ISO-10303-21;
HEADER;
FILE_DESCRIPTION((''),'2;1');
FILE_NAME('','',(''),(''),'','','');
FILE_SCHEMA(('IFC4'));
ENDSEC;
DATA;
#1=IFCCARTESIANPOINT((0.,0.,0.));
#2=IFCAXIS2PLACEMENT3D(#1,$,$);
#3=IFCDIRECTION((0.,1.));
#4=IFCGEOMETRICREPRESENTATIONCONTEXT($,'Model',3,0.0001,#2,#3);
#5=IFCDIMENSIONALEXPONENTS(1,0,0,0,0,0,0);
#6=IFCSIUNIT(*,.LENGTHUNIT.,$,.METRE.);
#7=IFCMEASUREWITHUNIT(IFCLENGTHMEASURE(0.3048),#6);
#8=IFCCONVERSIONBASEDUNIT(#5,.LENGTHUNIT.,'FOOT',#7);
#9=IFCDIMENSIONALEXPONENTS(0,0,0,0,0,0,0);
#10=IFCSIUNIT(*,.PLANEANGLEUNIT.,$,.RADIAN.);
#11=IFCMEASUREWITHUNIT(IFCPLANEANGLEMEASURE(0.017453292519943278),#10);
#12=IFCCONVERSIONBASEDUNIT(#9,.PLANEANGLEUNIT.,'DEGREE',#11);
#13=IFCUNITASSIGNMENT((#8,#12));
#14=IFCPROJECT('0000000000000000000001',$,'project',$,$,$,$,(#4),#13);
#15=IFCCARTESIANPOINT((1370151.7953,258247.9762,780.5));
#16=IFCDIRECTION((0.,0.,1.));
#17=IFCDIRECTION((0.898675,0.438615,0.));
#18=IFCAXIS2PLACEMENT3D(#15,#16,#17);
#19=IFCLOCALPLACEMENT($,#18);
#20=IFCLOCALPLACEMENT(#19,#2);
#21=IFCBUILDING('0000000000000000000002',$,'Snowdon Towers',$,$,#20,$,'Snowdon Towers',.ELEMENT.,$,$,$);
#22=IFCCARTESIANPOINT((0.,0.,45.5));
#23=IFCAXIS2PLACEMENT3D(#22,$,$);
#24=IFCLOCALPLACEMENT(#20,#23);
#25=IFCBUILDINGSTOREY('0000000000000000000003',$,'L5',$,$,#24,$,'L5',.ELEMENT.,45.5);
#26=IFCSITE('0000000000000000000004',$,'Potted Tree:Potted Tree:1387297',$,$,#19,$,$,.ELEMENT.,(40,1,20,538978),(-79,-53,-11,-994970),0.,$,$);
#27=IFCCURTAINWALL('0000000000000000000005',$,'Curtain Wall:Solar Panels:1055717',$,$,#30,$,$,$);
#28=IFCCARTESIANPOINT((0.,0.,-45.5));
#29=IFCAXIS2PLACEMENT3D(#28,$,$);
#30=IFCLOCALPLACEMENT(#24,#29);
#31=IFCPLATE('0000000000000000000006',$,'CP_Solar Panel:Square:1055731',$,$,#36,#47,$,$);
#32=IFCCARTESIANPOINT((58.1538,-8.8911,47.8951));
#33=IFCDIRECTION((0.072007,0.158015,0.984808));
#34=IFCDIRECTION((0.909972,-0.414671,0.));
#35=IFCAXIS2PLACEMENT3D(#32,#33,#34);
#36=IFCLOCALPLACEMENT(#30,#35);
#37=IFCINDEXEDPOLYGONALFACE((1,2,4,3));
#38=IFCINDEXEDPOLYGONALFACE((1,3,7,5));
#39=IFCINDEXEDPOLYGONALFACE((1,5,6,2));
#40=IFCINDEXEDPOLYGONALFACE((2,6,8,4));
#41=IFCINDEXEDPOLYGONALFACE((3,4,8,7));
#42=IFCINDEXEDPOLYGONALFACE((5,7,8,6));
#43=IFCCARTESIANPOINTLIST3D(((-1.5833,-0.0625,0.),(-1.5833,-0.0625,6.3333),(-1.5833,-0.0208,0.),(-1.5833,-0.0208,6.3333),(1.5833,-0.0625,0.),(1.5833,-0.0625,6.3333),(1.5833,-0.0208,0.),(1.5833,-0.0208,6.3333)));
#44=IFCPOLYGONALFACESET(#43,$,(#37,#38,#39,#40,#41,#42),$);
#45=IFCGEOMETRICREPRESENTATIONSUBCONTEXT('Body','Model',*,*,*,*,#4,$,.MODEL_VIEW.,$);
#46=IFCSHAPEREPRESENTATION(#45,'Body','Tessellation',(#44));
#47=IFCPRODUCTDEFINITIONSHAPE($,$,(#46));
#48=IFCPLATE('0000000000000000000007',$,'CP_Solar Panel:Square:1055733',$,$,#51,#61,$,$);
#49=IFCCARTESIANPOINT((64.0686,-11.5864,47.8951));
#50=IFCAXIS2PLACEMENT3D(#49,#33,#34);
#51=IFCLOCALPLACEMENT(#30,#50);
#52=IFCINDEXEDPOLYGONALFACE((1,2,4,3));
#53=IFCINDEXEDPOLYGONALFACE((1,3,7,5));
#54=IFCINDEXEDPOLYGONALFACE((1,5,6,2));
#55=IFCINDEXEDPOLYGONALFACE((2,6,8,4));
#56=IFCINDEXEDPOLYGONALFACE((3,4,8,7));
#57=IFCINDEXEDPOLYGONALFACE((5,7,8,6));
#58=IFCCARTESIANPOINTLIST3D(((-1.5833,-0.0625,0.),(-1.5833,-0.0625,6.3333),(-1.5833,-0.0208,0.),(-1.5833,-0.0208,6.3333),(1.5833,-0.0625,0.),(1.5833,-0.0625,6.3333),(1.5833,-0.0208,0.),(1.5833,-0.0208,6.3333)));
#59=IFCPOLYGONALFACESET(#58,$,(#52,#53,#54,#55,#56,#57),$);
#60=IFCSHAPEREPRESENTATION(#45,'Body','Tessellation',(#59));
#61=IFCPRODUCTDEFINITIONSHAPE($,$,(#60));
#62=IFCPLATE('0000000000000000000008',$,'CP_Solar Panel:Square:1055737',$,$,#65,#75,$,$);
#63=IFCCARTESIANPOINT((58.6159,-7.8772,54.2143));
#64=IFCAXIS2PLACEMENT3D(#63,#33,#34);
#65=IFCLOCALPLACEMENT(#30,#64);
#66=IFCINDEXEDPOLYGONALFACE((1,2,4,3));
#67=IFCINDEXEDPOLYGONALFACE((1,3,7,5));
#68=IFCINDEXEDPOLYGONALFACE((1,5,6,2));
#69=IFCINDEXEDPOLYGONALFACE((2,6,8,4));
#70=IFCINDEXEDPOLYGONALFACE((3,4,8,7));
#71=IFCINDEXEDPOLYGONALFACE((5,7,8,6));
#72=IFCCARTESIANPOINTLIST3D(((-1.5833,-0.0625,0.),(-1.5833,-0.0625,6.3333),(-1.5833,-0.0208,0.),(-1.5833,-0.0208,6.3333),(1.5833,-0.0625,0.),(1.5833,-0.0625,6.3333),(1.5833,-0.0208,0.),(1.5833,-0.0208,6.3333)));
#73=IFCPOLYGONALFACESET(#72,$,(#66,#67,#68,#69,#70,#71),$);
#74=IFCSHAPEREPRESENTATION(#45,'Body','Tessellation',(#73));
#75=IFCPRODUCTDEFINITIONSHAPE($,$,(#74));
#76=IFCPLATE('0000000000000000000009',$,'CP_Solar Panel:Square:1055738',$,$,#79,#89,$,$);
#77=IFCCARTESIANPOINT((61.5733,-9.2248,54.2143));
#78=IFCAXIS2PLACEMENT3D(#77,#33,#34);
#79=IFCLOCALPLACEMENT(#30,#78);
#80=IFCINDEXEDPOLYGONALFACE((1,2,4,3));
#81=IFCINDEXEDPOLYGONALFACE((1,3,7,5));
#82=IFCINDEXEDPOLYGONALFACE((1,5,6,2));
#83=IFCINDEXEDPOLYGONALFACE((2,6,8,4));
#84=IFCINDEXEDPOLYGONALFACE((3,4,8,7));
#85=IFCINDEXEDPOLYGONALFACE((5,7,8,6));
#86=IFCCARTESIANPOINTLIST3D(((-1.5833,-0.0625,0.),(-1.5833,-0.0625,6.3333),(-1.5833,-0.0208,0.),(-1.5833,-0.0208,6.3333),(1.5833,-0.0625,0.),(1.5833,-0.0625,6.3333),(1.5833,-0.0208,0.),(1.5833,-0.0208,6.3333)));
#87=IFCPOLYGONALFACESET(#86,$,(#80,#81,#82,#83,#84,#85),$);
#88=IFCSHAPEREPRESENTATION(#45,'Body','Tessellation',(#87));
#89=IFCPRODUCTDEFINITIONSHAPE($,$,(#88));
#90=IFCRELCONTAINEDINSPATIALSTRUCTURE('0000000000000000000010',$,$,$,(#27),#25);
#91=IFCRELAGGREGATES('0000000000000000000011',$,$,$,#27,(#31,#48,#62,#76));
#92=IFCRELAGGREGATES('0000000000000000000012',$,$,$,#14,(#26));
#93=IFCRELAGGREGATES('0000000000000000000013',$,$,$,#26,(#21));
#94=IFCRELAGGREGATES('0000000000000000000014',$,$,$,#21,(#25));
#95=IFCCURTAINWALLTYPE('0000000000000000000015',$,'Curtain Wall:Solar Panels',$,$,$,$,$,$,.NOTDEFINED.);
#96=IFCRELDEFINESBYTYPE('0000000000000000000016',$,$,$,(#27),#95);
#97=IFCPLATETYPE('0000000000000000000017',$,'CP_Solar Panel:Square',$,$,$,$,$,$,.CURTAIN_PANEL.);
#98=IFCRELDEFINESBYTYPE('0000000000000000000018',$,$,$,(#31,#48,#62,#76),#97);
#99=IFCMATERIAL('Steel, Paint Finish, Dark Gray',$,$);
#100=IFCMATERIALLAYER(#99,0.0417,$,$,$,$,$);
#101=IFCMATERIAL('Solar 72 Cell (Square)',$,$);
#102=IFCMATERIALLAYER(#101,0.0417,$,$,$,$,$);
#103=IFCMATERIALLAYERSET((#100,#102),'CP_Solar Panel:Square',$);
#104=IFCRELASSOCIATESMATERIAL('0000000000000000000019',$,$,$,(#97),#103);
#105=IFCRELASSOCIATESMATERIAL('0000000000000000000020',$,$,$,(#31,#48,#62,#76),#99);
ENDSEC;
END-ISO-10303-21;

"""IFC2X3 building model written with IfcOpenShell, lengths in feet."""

from ifc_helpers import new_model, entity, si_unit, converted_unit, direction, frame, origin, origin_2d_with_axis, place, context, subcontext, project, spatial, rectangle, extrude, source, transform, mapped, material, layer, layer_set, type_object, type_shapes, element, aggregate, save


model = new_model("IFC2X3")

# Units and contexts
model_context = context("Model", 3, precision=0.0001, world=origin(), true_north=direction((0.0, 1.0)))
body_context = subcontext(model_context, "Body", "Model", "MODEL_VIEW")
ifc_project = project(units=[converted_unit("LENGTHUNIT", "FOOT", entity("IfcLengthMeasure", 0.3048), si_unit("LENGTHUNIT", "METRE"), dimensions=[1, 0, 0, 0, 0, 0, 0]), converted_unit("PLANEANGLEUNIT", "DEGREE", entity("IfcPlaneAngleMeasure", 0.017453292519943278), si_unit("PLANEANGLEUNIT", "RADIAN"), dimensions=[0, 0, 0, 0, 0, 0, 0])], contexts=[model_context])

# Site, building, storey
site_placement = place(None, frame((1370151.7953, 258247.9762, 780.5), z_axis=(0.0, 0.0, 1.0), x_axis=(0.898675, 0.438615, 0.0)))
site = spatial("IfcSite", under=ifc_project, at=site_placement, Name="Potted Tree:Potted Tree:1387297", CompositionType="ELEMENT", RefLatitude=(40, 1, 20, 538978), RefLongitude=(-79, -53, -11, -994970), RefElevation=0.0)
building_placement = place(site_placement, origin())
building = spatial("IfcBuilding", under=site, at=building_placement, Name="Snowdon Towers", LongName="Snowdon Towers", CompositionType="ELEMENT")
storey_placement = place(building_placement, frame((0.0, 0.0, 45.5)))
storey = spatial("IfcBuildingStorey", under=building, at=storey_placement, Name="L5", LongName="L5", CompositionType="ELEMENT", Elevation=45.5)

# Curtain wall, plates
curtain_wall_type = type_object("IfcCurtainWallType", Name="Curtain Wall:Solar Panels", PredefinedType="NOTDEFINED")
curtain_wall_placement = place(storey_placement, frame((0.0, 0.0, -45.5)))
curtain_wall = element("IfcCurtainWall", 1, at=curtain_wall_placement, inside=storey, type_object=curtain_wall_type, Name="Curtain Wall:Solar Panels:1055717")
ifc_material_1 = material(Name="Steel, Paint Finish, Dark Gray")
ifc_layer_1 = layer(ifc_material_1, 0.0417)
ifc_material_2 = material(Name="Solar 72 Cell (Square)")
ifc_layer_2 = layer(ifc_material_2, 0.0417)
ifc_layer_set_1 = layer_set([ifc_layer_1, ifc_layer_2], Name="CP_Solar Panel:Square")
plate_type_1 = type_object("IfcPlateType", Name="CP_Solar Panel:Square", PredefinedType="CURTAIN_PANEL", material=ifc_layer_set_1)
shared_shape_1 = source(origin(), body_context, "Body", "SweptSolid", [
    extrude(rectangle(XDim=3.1667, YDim=0.0417, at=origin_2d_with_axis()), frame((0.0, -0.0417, 0.0)), (0.0, 0.0, 1.0), 6.3333),
])
type_shapes(plate_type_1, [shared_shape_1])
plate_1_placement = place(curtain_wall_placement, frame((58.1538, -8.8911, 47.8951), z_axis=(0.072007, 0.158015, 0.984808), x_axis=(0.909972, -0.414671, 0.0)))
plate_1 = element("IfcPlate", 2, at=plate_1_placement, type_object=plate_type_1, material=ifc_material_1, Name="CP_Solar Panel:Square:1055731", context=body_context, shape_type="MappedRepresentation", body=[
    mapped(shared_shape_1, transform((0.0, 0.0, 0.0), scale=1.0)),
])
plate_2_placement = place(curtain_wall_placement, frame((64.0686, -11.5864, 47.8951), z_axis=(0.072007, 0.158015, 0.984808), x_axis=(0.909972, -0.414671, 0.0)))
plate_2 = element("IfcPlate", 3, at=plate_2_placement, type_object=plate_type_1, material=ifc_material_1, Name="CP_Solar Panel:Square:1055733", context=body_context, shape_type="MappedRepresentation", body=[
    mapped(shared_shape_1, transform((0.0, 0.0, 0.0), scale=1.0)),
])
plate_3_placement = place(curtain_wall_placement, frame((58.6159, -7.8772, 54.2143), z_axis=(0.072007, 0.158015, 0.984808), x_axis=(0.909972, -0.414671, 0.0)))
plate_3 = element("IfcPlate", 4, at=plate_3_placement, type_object=plate_type_1, material=ifc_material_1, Name="CP_Solar Panel:Square:1055737", context=body_context, shape_type="MappedRepresentation", body=[
    mapped(shared_shape_1, transform((0.0, 0.0, 0.0), scale=1.0)),
])
plate_4_placement = place(curtain_wall_placement, frame((61.5733, -9.2248, 54.2143), z_axis=(0.072007, 0.158015, 0.984808), x_axis=(0.909972, -0.414671, 0.0)))
plate_4 = element("IfcPlate", 5, at=plate_4_placement, type_object=plate_type_1, material=ifc_material_1, Name="CP_Solar Panel:Square:1055738", context=body_context, shape_type="MappedRepresentation", body=[
    mapped(shared_shape_1, transform((0.0, 0.0, 0.0), scale=1.0)),
])
aggregate(curtain_wall, [plate_1, plate_2, plate_3, plate_4])

save(model, "model.ifc")
